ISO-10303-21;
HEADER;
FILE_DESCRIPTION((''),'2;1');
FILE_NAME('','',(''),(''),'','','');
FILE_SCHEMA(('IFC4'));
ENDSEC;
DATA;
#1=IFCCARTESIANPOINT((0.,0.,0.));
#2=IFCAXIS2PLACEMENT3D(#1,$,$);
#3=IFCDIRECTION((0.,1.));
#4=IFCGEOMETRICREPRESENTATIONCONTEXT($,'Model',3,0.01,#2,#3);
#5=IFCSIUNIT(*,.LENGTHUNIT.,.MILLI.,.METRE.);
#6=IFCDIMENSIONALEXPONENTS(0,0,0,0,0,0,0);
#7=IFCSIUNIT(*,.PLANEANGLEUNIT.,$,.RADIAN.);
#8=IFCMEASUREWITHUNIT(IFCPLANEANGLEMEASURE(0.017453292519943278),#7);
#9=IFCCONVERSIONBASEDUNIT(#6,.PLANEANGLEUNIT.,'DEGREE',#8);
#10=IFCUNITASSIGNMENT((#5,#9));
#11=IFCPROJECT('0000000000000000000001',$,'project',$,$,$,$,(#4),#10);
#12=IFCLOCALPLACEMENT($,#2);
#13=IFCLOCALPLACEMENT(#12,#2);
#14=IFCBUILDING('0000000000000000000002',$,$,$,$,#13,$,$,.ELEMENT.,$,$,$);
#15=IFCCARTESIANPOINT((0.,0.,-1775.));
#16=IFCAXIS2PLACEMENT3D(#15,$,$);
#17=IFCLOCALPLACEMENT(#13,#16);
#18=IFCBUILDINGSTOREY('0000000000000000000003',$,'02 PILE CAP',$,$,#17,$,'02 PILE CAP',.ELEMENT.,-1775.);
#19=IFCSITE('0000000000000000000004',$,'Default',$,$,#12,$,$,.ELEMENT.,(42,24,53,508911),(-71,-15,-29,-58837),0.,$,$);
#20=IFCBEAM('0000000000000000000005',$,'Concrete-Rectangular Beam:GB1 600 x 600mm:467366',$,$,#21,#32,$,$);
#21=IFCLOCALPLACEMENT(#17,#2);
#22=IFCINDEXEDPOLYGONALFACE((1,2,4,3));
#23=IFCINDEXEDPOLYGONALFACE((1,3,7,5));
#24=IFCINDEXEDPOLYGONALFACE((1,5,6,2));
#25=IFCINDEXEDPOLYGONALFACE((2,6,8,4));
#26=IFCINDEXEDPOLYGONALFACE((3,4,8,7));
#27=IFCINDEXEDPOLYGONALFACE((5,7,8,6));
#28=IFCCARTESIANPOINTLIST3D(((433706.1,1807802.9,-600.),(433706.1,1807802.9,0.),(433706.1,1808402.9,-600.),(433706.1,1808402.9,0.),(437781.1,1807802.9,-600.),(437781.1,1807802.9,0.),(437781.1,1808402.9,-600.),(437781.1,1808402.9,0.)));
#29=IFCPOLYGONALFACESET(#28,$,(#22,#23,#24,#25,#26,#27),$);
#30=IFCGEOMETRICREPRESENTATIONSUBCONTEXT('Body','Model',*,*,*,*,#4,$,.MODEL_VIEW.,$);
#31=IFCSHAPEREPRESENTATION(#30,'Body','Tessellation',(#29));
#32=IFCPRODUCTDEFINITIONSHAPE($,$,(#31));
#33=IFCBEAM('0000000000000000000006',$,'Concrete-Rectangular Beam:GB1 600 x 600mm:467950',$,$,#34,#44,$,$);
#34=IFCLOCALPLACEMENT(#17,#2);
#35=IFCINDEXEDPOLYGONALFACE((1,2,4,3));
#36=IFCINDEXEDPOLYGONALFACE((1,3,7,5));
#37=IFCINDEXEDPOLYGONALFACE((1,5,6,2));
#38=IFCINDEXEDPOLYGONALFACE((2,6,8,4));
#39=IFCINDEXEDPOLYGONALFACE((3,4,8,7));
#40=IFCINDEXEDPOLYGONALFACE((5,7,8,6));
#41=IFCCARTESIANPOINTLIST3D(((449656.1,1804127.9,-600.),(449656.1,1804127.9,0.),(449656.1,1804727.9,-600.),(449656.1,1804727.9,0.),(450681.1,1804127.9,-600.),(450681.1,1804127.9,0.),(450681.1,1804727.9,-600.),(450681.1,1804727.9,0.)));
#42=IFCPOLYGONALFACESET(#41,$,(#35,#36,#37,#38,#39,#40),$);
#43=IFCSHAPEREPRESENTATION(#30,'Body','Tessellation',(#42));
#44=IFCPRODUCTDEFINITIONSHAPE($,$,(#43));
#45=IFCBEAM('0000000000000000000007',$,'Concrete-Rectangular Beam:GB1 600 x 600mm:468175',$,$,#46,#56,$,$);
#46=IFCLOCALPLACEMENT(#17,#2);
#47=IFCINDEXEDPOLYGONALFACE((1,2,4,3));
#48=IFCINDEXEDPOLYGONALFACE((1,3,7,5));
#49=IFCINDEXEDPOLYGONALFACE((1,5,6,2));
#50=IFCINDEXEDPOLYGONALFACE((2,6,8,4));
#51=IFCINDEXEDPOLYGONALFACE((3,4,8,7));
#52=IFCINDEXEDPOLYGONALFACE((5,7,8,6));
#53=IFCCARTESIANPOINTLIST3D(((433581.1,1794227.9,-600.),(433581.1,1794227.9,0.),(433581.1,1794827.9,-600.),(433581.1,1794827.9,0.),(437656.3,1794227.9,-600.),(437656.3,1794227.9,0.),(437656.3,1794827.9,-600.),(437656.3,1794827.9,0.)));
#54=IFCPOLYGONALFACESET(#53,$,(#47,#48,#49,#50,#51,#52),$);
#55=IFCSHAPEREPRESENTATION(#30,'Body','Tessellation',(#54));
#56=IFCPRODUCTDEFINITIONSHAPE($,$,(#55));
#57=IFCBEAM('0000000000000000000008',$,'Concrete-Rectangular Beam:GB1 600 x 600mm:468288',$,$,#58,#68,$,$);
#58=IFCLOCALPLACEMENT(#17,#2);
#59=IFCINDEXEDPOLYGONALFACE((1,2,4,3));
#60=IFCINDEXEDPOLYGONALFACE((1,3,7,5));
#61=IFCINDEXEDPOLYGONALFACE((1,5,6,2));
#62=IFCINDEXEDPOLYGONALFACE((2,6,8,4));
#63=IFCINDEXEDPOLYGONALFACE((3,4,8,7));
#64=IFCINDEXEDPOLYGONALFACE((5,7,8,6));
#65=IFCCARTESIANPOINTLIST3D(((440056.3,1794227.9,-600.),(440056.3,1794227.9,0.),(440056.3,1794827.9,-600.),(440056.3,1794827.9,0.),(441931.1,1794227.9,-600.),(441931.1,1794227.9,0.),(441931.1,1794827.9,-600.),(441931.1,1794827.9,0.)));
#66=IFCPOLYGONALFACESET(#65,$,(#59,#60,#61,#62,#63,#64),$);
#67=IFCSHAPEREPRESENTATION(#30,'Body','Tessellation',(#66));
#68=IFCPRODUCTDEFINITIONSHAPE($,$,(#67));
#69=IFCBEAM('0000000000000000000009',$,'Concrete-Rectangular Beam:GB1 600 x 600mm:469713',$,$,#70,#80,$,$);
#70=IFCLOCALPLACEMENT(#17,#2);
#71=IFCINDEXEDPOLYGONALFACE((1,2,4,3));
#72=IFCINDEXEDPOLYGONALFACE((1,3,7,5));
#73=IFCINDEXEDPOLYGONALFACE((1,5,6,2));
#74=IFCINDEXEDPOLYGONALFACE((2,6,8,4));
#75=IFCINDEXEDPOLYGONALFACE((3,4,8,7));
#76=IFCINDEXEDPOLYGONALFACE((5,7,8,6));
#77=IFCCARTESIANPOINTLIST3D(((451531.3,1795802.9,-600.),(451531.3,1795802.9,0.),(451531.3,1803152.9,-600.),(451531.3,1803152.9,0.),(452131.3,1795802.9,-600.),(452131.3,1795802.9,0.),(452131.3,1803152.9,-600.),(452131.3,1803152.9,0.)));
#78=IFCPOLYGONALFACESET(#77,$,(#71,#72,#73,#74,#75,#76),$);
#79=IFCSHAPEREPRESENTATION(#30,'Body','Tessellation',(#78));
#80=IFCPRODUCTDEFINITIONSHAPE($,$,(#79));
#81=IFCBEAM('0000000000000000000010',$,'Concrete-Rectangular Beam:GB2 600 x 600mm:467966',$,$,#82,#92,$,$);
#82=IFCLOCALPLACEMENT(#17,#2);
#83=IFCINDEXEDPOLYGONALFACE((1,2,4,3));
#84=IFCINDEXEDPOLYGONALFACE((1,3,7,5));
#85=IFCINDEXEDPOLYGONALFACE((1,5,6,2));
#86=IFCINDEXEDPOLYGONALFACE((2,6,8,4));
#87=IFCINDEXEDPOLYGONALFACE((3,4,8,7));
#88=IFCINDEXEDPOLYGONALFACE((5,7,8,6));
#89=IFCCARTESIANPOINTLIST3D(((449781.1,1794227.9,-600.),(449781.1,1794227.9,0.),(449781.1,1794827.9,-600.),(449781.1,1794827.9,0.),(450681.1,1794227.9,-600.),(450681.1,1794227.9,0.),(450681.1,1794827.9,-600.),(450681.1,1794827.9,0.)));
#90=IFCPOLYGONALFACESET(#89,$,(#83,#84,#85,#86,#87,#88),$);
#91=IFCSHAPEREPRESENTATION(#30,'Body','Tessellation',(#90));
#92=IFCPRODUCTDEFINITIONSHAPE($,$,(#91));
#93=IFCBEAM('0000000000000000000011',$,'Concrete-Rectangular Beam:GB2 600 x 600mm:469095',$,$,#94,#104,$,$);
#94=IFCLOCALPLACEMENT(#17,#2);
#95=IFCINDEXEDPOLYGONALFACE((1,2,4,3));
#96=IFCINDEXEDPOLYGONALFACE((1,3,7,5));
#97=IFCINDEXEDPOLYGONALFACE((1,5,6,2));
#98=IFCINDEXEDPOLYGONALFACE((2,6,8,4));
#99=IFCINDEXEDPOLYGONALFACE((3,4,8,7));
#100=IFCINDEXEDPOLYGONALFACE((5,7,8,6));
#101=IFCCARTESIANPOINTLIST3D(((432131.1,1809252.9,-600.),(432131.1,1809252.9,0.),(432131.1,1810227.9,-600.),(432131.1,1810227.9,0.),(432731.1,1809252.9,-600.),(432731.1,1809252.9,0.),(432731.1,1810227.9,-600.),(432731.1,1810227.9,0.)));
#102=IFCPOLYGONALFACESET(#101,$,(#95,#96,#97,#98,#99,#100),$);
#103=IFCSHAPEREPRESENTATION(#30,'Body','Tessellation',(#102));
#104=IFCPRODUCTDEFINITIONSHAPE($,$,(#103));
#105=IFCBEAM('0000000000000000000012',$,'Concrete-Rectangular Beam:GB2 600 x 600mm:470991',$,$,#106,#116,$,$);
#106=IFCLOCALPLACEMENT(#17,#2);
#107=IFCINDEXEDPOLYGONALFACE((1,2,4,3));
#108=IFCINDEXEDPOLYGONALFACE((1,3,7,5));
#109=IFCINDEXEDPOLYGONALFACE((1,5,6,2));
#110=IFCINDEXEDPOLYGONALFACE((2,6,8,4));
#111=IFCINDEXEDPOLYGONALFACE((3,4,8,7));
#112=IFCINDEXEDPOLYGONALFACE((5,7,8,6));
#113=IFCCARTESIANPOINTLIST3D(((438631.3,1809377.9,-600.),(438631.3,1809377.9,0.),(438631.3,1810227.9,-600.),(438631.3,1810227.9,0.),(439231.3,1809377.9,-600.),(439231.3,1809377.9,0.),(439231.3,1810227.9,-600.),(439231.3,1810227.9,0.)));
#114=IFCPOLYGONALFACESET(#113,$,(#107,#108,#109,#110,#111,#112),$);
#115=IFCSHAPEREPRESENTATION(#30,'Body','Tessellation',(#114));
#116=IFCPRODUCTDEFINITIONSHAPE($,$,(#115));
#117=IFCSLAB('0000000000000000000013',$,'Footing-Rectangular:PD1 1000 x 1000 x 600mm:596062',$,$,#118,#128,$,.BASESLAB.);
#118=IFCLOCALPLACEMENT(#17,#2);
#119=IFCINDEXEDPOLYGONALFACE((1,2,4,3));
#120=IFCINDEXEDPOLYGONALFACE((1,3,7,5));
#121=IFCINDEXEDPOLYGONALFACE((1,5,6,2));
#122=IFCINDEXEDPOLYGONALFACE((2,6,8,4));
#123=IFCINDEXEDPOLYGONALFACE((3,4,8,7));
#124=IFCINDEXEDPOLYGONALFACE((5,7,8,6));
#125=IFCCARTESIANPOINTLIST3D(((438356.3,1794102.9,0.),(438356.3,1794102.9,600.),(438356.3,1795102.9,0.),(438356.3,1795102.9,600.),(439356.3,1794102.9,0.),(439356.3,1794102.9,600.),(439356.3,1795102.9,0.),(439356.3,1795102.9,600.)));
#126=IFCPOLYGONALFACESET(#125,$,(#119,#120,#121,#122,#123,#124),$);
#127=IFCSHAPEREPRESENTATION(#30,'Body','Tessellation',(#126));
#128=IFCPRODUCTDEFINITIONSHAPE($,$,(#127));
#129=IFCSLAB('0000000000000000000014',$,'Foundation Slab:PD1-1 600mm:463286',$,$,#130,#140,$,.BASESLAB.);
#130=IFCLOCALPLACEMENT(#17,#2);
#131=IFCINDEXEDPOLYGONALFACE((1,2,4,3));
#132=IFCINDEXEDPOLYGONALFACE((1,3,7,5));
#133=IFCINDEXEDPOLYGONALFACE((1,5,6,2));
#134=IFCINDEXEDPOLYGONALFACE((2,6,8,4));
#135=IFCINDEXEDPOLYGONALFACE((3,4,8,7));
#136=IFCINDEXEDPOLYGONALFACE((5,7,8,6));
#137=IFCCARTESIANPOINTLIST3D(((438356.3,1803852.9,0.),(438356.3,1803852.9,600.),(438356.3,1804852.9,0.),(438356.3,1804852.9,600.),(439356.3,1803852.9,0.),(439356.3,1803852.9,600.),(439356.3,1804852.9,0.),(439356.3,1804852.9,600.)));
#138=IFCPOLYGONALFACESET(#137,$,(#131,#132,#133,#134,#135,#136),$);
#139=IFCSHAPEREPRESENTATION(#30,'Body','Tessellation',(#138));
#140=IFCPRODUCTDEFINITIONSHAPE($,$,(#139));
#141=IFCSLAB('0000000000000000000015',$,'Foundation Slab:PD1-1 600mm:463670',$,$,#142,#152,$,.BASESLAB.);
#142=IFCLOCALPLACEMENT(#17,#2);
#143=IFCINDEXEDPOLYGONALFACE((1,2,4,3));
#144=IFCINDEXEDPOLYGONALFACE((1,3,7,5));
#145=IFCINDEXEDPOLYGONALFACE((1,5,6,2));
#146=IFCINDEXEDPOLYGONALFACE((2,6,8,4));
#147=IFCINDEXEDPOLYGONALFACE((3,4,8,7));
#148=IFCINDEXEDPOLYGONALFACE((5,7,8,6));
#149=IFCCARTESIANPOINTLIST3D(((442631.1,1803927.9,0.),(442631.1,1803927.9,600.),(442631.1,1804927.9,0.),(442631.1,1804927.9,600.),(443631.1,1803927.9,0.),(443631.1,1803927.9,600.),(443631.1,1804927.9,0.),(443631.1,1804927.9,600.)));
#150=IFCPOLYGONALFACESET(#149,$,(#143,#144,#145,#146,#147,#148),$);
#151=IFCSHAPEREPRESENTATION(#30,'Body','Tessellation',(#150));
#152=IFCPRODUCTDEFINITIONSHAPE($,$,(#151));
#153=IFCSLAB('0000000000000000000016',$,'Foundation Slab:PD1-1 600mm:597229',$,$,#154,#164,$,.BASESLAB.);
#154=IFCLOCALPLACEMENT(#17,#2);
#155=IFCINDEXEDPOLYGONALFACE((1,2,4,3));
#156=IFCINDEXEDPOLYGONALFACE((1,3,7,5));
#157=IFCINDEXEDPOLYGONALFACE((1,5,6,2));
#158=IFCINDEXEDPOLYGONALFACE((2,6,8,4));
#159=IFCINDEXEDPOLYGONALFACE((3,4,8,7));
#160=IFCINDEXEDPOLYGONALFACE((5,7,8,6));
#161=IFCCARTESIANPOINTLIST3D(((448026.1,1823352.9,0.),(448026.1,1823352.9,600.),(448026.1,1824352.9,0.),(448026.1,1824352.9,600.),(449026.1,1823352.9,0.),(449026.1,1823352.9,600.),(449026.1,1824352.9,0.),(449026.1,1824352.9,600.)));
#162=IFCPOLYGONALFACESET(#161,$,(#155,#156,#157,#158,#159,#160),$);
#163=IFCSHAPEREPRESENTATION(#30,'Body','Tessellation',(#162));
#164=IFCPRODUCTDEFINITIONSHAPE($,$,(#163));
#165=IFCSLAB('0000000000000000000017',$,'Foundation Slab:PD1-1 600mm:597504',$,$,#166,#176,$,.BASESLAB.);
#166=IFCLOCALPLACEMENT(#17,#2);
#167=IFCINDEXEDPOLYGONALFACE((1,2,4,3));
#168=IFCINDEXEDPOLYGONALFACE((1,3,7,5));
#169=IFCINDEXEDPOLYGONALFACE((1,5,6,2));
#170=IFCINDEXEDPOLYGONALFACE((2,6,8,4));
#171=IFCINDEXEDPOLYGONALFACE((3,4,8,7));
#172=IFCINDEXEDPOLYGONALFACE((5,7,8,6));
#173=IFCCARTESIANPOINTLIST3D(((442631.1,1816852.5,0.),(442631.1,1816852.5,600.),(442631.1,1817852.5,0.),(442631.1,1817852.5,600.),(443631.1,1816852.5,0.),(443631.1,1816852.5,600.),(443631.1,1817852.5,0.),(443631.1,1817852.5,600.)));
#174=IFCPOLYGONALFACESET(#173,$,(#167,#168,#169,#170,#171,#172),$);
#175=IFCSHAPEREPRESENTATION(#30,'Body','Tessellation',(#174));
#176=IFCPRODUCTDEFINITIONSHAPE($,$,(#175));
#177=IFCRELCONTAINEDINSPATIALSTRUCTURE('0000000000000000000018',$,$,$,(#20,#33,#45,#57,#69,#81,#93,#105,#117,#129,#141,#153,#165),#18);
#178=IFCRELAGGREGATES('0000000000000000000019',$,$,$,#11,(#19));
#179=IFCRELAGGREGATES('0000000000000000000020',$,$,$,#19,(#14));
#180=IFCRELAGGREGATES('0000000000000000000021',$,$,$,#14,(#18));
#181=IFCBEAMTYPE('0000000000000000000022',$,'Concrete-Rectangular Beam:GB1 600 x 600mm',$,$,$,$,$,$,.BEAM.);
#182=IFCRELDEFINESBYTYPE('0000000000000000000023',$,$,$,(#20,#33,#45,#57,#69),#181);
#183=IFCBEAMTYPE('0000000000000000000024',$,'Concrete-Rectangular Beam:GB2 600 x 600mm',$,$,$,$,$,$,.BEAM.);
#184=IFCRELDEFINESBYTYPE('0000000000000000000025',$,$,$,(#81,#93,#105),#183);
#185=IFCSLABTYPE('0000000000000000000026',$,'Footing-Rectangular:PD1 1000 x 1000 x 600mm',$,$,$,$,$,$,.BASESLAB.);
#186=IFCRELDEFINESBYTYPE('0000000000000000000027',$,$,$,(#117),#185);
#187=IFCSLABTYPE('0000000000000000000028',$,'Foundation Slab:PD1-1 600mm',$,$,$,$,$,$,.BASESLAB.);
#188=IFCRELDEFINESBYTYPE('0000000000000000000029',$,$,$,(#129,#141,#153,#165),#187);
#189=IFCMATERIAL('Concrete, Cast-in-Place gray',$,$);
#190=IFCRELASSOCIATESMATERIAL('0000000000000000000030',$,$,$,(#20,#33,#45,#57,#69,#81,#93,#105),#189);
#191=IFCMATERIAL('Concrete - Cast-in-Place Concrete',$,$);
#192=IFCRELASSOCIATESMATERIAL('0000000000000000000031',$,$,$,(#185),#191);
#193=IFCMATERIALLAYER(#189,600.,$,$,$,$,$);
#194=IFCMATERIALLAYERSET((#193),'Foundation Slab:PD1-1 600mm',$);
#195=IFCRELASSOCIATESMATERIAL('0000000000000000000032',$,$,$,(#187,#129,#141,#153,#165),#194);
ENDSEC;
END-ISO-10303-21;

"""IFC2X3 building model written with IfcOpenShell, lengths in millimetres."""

from ifc_helpers import new_model, entity, si_unit, converted_unit, direction, frame, frame_2d, origin, origin_2d_with_axis, place, context, subcontext, project, spatial, rectangle, extrude, material, layer, layer_set, layer_usage, type_object, element, save


model = new_model("IFC2X3")

# Units and contexts
model_context = context("Model", 3, precision=0.01, world=origin(), true_north=direction((0.0, 1.0)))
body_context = subcontext(model_context, "Body", "Model", "MODEL_VIEW")
ifc_project = project(units=[si_unit("LENGTHUNIT", "METRE", prefix="MILLI"), converted_unit("PLANEANGLEUNIT", "DEGREE", entity("IfcPlaneAngleMeasure", 0.017453292519943278), si_unit("PLANEANGLEUNIT", "RADIAN"), dimensions=[0, 0, 0, 0, 0, 0, 0])], contexts=[model_context])

# Site, building, storey
site_placement = place(None, origin())
site = spatial("IfcSite", under=ifc_project, at=site_placement, Name="Default", CompositionType="ELEMENT", RefLatitude=(42, 24, 53, 508911), RefLongitude=(-71, -15, -29, -58837), RefElevation=0.0)
building_placement = place(site_placement, origin())
building = spatial("IfcBuilding", under=site, at=building_placement, CompositionType="ELEMENT")
storey_placement = place(building_placement, frame((0.0, 0.0, -1775.0)))
storey = spatial("IfcBuildingStorey", under=building, at=storey_placement, Name="02 PILE CAP", LongName="02 PILE CAP", CompositionType="ELEMENT", Elevation=-1775.0)

# Beams
ifc_material_1 = material(Name="Concrete, Cast-in-Place gray")
beam_type_1 = type_object("IfcBeamType", Name="Concrete-Rectangular Beam:GB1 600 x 600mm", PredefinedType="BEAM")
beam_1_placement = place(storey_placement, frame((437781.3, 1808102.9, 0.0), z_axis=(0.0, 0.0, 1.0), x_axis=(-1.0, 0.0, 0.0)))
element("IfcBeam", 1, at=beam_1_placement, inside=storey, type_object=beam_type_1, material=ifc_material_1, Name="Concrete-Rectangular Beam:GB1 600 x 600mm:467366", context=body_context, shape_type="SweptSolid", body=[
    extrude(rectangle(XDim=600.0, YDim=600.0, at=frame_2d((0.0, 0.0), x_axis=(1.0, 0.0))), frame((0.2, 0.0, -300.0), z_axis=(1.0, 0.0, 0.0), x_axis=(0.0, 0.0, -1.0)), (0.0, 0.0, 1.0), 4075.0),
])
beam_2_placement = place(storey_placement, frame((449656.1, 1804427.9, 0.0)))
element("IfcBeam", 2, at=beam_2_placement, inside=storey, type_object=beam_type_1, material=ifc_material_1, Name="Concrete-Rectangular Beam:GB1 600 x 600mm:467950", context=body_context, shape_type="SweptSolid", body=[
    extrude(rectangle(XDim=600.0, YDim=600.0, at=origin_2d_with_axis()), frame((0.0, 0.0, -300.0), z_axis=(1.0, 0.0, 0.0), x_axis=(0.0, 0.0, -1.0)), (0.0, 0.0, 1.0), 1025.0),
])
beam_3_placement = place(storey_placement, frame((437656.3, 1794527.9, 0.0), z_axis=(0.0, 0.0, 1.0), x_axis=(-1.0, 0.0, 0.0)))
element("IfcBeam", 3, at=beam_3_placement, inside=storey, type_object=beam_type_1, material=ifc_material_1, Name="Concrete-Rectangular Beam:GB1 600 x 600mm:468175", context=body_context, shape_type="SweptSolid", body=[
    extrude(rectangle(XDim=600.0, YDim=600.0, at=frame_2d((0.0, 0.0), x_axis=(1.0, 0.0))), frame((0.0, 0.0, -300.0), z_axis=(1.0, 0.0, 0.0), x_axis=(0.0, 0.0, -1.0)), (0.0, 0.0, 1.0), 4075.2),
])
beam_4_placement = place(storey_placement, frame((440056.3, 1794527.9, 0.0)))
element("IfcBeam", 4, at=beam_4_placement, inside=storey, type_object=beam_type_1, material=ifc_material_1, Name="Concrete-Rectangular Beam:GB1 600 x 600mm:468288", context=body_context, shape_type="SweptSolid", body=[
    extrude(rectangle(XDim=600.0, YDim=600.0, at=frame_2d((0.0, 0.0), x_axis=(1.0, 0.0))), frame((0.0, 0.0, -300.0), z_axis=(1.0, 0.0, 0.0), x_axis=(0.0, 0.0, -1.0)), (0.0, 0.0, 1.0), 1874.8),
])
beam_5_placement = place(storey_placement, frame((451831.3, 1803152.9, 0.0), z_axis=(0.0, 0.0, 1.0), x_axis=(0.0, -1.0, 0.0)))
element("IfcBeam", 5, at=beam_5_placement, inside=storey, type_object=beam_type_1, material=ifc_material_1, Name="Concrete-Rectangular Beam:GB1 600 x 600mm:469713", context=body_context, shape_type="SweptSolid", body=[
    extrude(rectangle(XDim=600.0, YDim=600.0, at=origin_2d_with_axis()), frame((0.0, 0.0, -300.0), z_axis=(1.0, 0.0, 0.0), x_axis=(0.0, 0.0, -1.0)), (0.0, 0.0, 1.0), 7350.0),
])
beam_type_2 = type_object("IfcBeamType", Name="Concrete-Rectangular Beam:GB2 600 x 600mm", PredefinedType="BEAM")
beam_6_placement = place(storey_placement, frame((449781.1, 1794527.9, 0.0)))
element("IfcBeam", 6, at=beam_6_placement, inside=storey, type_object=beam_type_2, material=ifc_material_1, Name="Concrete-Rectangular Beam:GB2 600 x 600mm:467966", context=body_context, shape_type="SweptSolid", body=[
    extrude(rectangle(XDim=600.0, YDim=600.0, at=frame_2d((0.0, 0.0), x_axis=(1.0, 0.0))), frame((0.0, 0.0, -300.0), z_axis=(1.0, 0.0, 0.0), x_axis=(0.0, 0.0, -1.0)), (0.0, 0.0, 1.0), 900.0),
])
beam_7_placement = place(storey_placement, frame((432431.1, 1810227.9, 0.0), z_axis=(0.0, 0.0, 1.0), x_axis=(0.0, -1.0, 0.0)))
element("IfcBeam", 7, at=beam_7_placement, inside=storey, type_object=beam_type_2, material=ifc_material_1, Name="Concrete-Rectangular Beam:GB2 600 x 600mm:469095", context=body_context, shape_type="SweptSolid", body=[
    extrude(rectangle(XDim=600.0, YDim=600.0, at=origin_2d_with_axis()), frame((0.0, 0.0, -300.0), z_axis=(1.0, 0.0, 0.0), x_axis=(0.0, 0.0, -1.0)), (0.0, 0.0, 1.0), 975.0),
])
beam_8_placement = place(storey_placement, frame((438931.3, 1810227.9, 0.0), z_axis=(0.0, 0.0, 1.0), x_axis=(0.0, -1.0, 0.0)))
element("IfcBeam", 8, at=beam_8_placement, inside=storey, type_object=beam_type_2, material=ifc_material_1, Name="Concrete-Rectangular Beam:GB2 600 x 600mm:470991", context=body_context, shape_type="SweptSolid", body=[
    extrude(rectangle(XDim=600.0, YDim=600.0, at=origin_2d_with_axis()), frame((0.0, 0.0, -300.0), z_axis=(1.0, 0.0, 0.0), x_axis=(0.0, 0.0, -1.0)), (0.0, 0.0, 1.0), 850.0),
])

# Slabs
ifc_material_2 = material(Name="Concrete - Cast-in-Place Concrete")
slab_type_1 = type_object("IfcSlabType", Name="Footing-Rectangular:PD1 1000 x 1000 x 600mm", PredefinedType="BASESLAB", material=ifc_material_2)
slab_1_placement = place(storey_placement, origin())
element("IfcSlab", 9, at=slab_1_placement, inside=storey, type_object=slab_type_1, Name="Footing-Rectangular:PD1 1000 x 1000 x 600mm:596062", PredefinedType="BASESLAB", context=body_context, shape_type="SweptSolid", body=[
    extrude(rectangle(XDim=1000.0, YDim=1000.0, at=frame_2d((0.0, 0.0), x_axis=(1.0, 0.0))), frame((438856.3, 1794602.9, 0.0), z_axis=(0.0, 0.0, 1.0), x_axis=(-1.0, 0.0, 0.0)), (0.0, 0.0, 1.0), 600.0),
])
ifc_layer = layer(ifc_material_1, 600.0)
ifc_layer_set = layer_set([ifc_layer], Name="Foundation Slab:PD1-1 600mm")
ifc_layer_usage_1 = layer_usage(ifc_layer_set, "AXIS3", "POSITIVE", 0.0)
slab_type_2 = type_object("IfcSlabType", Name="Foundation Slab:PD1-1 600mm", PredefinedType="BASESLAB", material=ifc_layer_set)
slab_2_placement = place(storey_placement, origin())
element("IfcSlab", 10, at=slab_2_placement, inside=storey, type_object=slab_type_2, material=ifc_layer_usage_1, Name="Foundation Slab:PD1-1 600mm:463286", PredefinedType="BASESLAB", context=body_context, shape_type="SweptSolid", body=[
    extrude(rectangle(XDim=1000.0, YDim=1000.0, at=frame_2d((0.0, 0.0), x_axis=(1.0, 0.0))), frame((438856.3, 1804352.9, 600.0), z_axis=(0.0, 0.0, -1.0), x_axis=(0.0, 1.0, 0.0)), (0.0, 0.0, 1.0), 600.0),
])
ifc_layer_usage_2 = layer_usage(ifc_layer_set, "AXIS3", "POSITIVE", 0.0)
slab_3_placement = place(storey_placement, origin())
element("IfcSlab", 11, at=slab_3_placement, inside=storey, type_object=slab_type_2, material=ifc_layer_usage_2, Name="Foundation Slab:PD1-1 600mm:463670", PredefinedType="BASESLAB", context=body_context, shape_type="SweptSolid", body=[
    extrude(rectangle(XDim=1000.0, YDim=1000.0, at=frame_2d((0.0, 0.0), x_axis=(1.0, 0.0))), frame((443131.1, 1804427.9, 600.0), z_axis=(0.0, 0.0, -1.0), x_axis=(0.0, 1.0, 0.0)), (0.0, 0.0, 1.0), 600.0),
])
ifc_layer_usage_3 = layer_usage(ifc_layer_set, "AXIS3", "POSITIVE", 0.0)
slab_4_placement = place(storey_placement, origin())
element("IfcSlab", 12, at=slab_4_placement, inside=storey, type_object=slab_type_2, material=ifc_layer_usage_3, Name="Foundation Slab:PD1-1 600mm:597229", PredefinedType="BASESLAB", context=body_context, shape_type="SweptSolid", body=[
    extrude(rectangle(XDim=1000.0, YDim=1000.0, at=frame_2d((0.0, 0.0), x_axis=(1.0, 0.0))), frame((448526.1, 1823852.9, 600.0), z_axis=(0.0, 0.0, -1.0), x_axis=(0.0, 1.0, 0.0)), (0.0, 0.0, 1.0), 600.0),
])
ifc_layer_usage_4 = layer_usage(ifc_layer_set, "AXIS3", "POSITIVE", 0.0)
slab_5_placement = place(storey_placement, origin())
element("IfcSlab", 13, at=slab_5_placement, inside=storey, type_object=slab_type_2, material=ifc_layer_usage_4, Name="Foundation Slab:PD1-1 600mm:597504", PredefinedType="BASESLAB", context=body_context, shape_type="SweptSolid", body=[
    extrude(rectangle(XDim=1000.0, YDim=1000.0, at=frame_2d((0.0, 0.0), x_axis=(1.0, 0.0))), frame((443131.1, 1817352.5, 600.0), z_axis=(0.0, 0.0, -1.0), x_axis=(0.0, 1.0, 0.0)), (0.0, 0.0, 1.0), 600.0),
])

save(model, "model.ifc")
